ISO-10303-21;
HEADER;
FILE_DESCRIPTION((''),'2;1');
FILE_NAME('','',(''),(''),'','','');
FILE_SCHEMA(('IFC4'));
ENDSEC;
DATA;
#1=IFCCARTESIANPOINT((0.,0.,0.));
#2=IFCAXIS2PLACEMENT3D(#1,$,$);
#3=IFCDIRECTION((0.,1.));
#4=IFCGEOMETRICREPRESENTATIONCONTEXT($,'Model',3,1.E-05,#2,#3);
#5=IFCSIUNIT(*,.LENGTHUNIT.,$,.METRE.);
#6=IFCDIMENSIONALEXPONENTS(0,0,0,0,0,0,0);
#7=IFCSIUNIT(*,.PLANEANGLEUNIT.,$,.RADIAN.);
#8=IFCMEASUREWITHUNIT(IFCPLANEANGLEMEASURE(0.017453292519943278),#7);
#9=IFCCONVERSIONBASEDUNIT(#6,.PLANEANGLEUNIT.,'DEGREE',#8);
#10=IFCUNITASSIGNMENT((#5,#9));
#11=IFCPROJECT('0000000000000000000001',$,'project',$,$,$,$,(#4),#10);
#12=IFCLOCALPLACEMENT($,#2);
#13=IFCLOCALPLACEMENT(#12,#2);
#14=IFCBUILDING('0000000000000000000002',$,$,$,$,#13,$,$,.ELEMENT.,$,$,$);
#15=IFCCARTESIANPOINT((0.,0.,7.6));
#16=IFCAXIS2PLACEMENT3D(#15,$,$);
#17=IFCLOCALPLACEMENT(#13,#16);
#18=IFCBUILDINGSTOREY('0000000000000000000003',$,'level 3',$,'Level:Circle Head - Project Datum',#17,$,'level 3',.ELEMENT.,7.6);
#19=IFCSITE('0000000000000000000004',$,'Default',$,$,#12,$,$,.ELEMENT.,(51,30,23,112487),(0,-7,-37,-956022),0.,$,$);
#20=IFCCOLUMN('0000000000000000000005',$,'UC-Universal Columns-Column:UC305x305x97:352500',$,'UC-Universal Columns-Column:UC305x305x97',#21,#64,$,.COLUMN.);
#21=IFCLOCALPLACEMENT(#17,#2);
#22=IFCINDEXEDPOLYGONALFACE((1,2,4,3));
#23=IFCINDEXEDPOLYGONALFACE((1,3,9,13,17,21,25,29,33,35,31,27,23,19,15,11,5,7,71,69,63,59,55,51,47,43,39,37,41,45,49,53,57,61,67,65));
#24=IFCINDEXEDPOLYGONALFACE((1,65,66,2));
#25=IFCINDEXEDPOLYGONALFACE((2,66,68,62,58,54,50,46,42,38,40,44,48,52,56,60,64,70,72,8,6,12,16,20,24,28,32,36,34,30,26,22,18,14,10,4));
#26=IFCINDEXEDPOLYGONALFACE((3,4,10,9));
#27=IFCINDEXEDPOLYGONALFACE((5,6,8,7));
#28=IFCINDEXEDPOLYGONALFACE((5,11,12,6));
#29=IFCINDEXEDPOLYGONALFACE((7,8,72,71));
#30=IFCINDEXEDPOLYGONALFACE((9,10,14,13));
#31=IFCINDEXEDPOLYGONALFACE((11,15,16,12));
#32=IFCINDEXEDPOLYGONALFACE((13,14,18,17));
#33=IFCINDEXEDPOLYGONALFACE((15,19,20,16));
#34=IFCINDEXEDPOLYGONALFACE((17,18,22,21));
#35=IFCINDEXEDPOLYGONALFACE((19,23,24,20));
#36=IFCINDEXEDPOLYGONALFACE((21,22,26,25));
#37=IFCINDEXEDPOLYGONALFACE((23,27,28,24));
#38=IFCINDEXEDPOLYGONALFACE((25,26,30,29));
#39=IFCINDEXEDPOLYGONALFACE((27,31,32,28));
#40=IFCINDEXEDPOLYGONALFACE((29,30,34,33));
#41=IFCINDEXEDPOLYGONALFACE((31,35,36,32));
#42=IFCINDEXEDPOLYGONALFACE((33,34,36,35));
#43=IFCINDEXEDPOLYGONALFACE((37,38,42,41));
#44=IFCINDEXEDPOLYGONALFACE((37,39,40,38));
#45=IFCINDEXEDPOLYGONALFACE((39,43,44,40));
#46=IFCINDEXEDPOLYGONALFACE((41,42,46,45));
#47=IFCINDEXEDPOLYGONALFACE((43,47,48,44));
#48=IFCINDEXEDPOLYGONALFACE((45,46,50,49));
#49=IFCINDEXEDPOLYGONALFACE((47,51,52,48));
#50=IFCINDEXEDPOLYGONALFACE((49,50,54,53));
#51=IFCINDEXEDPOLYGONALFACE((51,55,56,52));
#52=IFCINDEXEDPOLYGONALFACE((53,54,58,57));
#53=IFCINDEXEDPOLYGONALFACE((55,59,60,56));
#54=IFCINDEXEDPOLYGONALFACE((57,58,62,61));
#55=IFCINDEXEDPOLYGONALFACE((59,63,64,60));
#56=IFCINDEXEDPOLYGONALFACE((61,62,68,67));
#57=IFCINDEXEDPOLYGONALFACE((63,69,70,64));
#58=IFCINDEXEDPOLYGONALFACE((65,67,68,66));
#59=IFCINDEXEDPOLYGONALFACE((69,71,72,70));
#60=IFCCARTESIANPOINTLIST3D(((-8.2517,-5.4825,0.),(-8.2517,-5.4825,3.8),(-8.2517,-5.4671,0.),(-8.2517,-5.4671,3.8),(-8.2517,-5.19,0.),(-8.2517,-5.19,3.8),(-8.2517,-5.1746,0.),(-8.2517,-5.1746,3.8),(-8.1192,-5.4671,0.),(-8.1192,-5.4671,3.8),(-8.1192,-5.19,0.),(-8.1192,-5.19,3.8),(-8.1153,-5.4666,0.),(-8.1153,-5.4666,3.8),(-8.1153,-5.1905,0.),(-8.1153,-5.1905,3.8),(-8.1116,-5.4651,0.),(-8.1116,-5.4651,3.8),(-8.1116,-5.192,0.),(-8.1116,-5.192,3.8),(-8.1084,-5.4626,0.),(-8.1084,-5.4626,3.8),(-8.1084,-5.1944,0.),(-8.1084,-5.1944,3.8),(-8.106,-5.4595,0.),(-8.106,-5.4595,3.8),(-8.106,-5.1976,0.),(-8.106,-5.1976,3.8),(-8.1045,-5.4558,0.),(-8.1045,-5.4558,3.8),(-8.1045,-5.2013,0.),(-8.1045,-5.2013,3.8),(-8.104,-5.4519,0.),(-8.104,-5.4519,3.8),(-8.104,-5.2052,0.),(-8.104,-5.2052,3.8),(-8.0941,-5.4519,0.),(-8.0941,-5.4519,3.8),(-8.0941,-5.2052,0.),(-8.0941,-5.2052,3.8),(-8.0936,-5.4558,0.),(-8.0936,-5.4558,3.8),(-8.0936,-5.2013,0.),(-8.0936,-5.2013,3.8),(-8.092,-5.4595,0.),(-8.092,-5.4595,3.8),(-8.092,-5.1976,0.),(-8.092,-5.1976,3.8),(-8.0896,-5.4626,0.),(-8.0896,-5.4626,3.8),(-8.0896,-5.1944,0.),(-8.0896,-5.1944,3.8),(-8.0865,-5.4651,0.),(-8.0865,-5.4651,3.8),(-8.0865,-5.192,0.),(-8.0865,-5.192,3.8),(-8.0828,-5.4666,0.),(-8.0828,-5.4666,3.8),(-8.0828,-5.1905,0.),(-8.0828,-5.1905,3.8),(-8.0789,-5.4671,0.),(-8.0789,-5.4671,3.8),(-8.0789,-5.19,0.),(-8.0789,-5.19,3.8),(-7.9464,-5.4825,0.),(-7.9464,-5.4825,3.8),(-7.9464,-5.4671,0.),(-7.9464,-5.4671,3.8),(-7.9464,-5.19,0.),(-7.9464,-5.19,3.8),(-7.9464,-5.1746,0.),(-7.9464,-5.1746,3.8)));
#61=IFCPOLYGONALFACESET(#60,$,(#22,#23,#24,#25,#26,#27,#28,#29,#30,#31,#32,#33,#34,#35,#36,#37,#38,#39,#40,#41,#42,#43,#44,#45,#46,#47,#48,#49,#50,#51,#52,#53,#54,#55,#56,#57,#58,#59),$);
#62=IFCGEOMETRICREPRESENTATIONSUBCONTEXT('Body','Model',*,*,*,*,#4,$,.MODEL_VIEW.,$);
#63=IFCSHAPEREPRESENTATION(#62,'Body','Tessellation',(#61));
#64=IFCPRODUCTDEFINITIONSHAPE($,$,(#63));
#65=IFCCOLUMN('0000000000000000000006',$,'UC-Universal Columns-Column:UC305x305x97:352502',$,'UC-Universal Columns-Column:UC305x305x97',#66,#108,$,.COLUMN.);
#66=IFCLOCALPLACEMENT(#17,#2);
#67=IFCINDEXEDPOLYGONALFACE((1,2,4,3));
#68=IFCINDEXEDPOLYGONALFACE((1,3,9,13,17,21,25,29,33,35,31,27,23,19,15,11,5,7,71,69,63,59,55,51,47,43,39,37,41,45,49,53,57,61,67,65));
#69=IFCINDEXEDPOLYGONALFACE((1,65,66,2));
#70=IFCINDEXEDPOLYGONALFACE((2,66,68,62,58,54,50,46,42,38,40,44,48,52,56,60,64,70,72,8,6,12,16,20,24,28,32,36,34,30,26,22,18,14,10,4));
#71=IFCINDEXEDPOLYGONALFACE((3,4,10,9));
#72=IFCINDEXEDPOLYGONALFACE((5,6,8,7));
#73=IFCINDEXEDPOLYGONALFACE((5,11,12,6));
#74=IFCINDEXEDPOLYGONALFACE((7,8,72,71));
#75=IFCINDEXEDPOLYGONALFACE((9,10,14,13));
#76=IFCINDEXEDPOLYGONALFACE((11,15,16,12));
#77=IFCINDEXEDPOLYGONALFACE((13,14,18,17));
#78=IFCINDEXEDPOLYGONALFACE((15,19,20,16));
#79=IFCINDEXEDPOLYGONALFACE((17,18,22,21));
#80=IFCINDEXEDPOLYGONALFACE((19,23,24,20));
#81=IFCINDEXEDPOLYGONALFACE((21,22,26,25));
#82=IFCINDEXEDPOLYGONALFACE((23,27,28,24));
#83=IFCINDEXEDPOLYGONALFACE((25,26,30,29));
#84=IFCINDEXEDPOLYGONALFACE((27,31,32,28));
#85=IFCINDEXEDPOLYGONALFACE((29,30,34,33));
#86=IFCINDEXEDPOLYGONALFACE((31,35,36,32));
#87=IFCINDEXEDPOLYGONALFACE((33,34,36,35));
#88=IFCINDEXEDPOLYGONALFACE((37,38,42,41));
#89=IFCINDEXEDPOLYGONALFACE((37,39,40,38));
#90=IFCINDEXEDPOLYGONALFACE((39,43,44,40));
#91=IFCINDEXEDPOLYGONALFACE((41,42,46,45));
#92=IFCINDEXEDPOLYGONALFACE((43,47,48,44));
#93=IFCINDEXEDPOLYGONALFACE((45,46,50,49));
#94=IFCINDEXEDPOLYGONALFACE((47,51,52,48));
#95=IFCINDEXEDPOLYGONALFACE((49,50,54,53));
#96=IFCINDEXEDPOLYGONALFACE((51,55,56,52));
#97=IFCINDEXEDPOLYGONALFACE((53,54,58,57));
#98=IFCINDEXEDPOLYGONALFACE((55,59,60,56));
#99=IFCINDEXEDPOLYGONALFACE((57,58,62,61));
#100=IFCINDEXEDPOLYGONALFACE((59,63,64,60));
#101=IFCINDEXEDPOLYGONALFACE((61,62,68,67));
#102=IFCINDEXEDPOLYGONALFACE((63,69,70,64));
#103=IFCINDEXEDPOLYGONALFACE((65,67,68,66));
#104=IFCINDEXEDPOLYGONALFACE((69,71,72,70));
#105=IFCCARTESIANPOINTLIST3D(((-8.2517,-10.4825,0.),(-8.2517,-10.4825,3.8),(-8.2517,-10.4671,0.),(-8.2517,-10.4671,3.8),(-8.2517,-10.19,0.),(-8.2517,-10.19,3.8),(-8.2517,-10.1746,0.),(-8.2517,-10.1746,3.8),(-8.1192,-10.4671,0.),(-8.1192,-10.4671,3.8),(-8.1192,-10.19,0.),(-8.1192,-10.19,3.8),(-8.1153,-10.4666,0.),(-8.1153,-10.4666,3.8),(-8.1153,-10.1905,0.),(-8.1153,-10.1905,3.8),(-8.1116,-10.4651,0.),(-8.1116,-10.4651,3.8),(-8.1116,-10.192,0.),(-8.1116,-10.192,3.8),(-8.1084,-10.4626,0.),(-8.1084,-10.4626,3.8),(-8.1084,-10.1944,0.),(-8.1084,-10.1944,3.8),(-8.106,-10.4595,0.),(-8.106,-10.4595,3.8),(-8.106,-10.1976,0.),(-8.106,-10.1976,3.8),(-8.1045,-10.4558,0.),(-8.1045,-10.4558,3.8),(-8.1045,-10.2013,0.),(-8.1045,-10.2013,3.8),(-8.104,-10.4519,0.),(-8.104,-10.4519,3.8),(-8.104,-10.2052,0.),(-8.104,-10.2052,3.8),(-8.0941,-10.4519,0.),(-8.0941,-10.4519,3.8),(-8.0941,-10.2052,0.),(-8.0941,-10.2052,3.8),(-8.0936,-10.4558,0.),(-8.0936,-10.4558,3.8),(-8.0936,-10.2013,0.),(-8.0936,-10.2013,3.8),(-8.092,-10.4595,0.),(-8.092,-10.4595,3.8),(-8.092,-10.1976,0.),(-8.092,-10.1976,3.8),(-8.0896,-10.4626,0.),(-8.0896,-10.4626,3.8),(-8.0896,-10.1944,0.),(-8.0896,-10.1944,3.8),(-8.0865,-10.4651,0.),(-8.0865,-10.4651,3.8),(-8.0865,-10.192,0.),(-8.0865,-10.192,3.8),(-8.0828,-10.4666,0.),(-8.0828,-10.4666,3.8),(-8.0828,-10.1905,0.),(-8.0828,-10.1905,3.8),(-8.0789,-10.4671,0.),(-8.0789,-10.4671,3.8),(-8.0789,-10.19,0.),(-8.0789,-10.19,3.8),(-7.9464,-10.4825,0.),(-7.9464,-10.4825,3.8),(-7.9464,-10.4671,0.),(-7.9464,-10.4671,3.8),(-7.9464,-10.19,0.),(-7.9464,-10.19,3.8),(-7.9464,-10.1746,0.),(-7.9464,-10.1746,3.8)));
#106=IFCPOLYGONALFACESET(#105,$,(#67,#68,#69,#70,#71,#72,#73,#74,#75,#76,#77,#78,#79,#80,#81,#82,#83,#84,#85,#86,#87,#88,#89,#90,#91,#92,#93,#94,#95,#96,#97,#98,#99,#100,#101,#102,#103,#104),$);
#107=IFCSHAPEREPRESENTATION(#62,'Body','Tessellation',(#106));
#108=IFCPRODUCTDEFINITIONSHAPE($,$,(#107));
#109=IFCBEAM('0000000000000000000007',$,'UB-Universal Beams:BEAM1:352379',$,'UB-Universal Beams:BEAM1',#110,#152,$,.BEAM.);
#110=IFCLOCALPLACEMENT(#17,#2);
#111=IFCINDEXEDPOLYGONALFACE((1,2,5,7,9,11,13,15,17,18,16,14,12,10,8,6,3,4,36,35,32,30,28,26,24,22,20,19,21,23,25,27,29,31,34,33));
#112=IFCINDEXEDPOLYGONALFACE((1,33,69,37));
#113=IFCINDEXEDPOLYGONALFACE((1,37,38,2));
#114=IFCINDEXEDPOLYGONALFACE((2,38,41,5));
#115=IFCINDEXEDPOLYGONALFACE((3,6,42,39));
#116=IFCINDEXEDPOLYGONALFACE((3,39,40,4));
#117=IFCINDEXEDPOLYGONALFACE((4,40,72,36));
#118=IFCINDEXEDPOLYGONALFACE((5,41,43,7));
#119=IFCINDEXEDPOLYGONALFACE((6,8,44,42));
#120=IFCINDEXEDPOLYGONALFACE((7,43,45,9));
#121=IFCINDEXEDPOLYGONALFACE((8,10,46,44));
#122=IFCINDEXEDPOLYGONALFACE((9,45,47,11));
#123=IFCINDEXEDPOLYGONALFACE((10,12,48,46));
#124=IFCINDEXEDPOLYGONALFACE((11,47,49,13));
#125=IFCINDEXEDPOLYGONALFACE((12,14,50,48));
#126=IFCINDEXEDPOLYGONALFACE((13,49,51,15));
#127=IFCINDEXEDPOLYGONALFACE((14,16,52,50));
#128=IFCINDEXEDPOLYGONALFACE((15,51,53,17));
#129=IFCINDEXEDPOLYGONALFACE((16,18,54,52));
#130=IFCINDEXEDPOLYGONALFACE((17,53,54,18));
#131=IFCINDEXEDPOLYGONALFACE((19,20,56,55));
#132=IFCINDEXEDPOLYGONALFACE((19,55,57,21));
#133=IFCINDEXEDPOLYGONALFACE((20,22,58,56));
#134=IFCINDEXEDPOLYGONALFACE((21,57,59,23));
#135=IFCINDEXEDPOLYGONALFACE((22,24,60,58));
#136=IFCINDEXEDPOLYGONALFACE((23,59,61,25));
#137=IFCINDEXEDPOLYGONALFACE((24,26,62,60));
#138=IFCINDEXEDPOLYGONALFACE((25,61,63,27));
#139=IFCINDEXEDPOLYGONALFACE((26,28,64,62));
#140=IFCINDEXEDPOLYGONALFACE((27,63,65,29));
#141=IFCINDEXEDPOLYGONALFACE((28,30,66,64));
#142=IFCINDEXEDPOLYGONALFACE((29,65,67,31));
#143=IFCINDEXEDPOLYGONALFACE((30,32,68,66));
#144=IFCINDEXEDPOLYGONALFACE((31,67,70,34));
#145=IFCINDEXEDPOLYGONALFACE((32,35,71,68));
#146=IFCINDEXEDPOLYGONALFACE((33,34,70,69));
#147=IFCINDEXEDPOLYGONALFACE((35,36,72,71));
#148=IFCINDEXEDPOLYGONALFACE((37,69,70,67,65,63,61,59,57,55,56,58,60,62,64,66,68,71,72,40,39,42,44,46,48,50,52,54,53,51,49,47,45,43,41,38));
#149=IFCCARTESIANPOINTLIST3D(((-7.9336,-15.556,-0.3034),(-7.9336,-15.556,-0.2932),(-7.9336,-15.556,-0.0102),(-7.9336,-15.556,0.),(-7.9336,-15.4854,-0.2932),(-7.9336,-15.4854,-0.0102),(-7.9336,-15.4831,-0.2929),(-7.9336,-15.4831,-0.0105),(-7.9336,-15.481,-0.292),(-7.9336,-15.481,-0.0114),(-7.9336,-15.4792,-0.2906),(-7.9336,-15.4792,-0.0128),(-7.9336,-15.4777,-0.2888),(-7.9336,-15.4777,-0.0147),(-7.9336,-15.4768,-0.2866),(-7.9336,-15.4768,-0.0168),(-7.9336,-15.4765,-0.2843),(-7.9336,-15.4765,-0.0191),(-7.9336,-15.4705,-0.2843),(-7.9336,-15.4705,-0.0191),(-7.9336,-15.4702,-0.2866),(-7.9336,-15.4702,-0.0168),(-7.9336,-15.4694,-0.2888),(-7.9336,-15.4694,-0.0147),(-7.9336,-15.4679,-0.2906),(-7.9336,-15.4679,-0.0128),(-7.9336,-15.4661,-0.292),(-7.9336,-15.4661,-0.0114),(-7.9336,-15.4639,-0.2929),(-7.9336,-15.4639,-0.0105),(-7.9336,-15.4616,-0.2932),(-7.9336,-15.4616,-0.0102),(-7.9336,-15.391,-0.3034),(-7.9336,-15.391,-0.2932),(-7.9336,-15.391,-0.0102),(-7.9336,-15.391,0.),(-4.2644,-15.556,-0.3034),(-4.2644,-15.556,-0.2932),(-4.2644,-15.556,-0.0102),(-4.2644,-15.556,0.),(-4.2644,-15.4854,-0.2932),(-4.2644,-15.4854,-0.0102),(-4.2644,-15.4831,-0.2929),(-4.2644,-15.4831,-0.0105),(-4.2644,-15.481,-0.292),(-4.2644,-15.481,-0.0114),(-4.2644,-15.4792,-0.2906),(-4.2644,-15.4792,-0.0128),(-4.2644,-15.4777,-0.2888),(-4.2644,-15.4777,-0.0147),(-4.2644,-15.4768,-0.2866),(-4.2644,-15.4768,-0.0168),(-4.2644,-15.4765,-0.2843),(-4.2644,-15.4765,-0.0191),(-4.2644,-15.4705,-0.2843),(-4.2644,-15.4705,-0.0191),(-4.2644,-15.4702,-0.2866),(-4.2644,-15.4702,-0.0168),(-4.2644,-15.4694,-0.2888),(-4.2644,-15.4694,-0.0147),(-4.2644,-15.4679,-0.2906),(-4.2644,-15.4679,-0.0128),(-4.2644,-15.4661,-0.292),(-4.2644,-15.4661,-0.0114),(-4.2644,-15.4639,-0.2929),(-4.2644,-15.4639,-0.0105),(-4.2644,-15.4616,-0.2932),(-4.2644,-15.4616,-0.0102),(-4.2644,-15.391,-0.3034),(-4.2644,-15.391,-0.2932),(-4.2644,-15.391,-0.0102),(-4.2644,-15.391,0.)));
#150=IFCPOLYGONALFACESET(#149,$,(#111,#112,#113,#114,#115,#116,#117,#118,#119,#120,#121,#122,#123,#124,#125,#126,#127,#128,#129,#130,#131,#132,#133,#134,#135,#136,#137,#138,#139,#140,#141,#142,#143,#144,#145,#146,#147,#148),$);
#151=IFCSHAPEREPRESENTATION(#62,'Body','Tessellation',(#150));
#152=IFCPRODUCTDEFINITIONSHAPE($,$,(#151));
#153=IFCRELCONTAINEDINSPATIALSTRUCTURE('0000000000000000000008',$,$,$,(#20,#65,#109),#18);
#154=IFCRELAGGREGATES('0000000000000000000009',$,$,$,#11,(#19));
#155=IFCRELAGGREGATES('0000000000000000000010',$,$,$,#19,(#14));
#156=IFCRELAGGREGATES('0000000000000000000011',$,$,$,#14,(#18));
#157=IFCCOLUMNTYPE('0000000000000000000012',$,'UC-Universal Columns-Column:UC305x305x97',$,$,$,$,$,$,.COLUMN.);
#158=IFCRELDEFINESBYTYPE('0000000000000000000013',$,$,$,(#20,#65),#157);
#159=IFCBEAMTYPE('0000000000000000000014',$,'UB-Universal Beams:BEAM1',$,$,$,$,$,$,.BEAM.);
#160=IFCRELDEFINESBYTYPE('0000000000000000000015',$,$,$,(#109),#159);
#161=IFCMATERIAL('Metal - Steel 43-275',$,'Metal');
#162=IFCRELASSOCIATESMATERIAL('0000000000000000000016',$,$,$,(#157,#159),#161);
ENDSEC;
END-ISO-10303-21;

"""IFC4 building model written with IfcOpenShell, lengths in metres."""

from ifc_helpers import new_model, entity, si_unit, converted_unit, direction, frame, frame_2d, origin, origin_2d_with_axis, place, context, subcontext, project, spatial, polyline, circle_curve, parameter, trimmed, segment, composite_curve, i_section, outline, extrude, source, transform, mapped, material, material_profile, profile_set, type_object, type_shapes, element, save


model = new_model("IFC4")

# Units and contexts
model_context = context("Model", 3, precision=1e-05, world=origin(), true_north=direction((0.0, 1.0)))
body_context = subcontext(model_context, "Body", "Model", "MODEL_VIEW")
ifc_project = project(units=[si_unit("LENGTHUNIT", "METRE"), converted_unit("PLANEANGLEUNIT", "DEGREE", entity("IfcPlaneAngleMeasure", 0.017453292519943278), si_unit("PLANEANGLEUNIT", "RADIAN"), dimensions=[0, 0, 0, 0, 0, 0, 0])], contexts=[model_context])

# Site, building, storey
site_placement = place(None, origin())
site = spatial("IfcSite", under=ifc_project, at=site_placement, Name="Default", CompositionType="ELEMENT", RefLatitude=(51, 30, 23, 112487), RefLongitude=(0, -7, -37, -956022), RefElevation=0.0)
building_placement = place(site_placement, origin())
building = spatial("IfcBuilding", under=site, at=building_placement, CompositionType="ELEMENT")
storey_placement = place(building_placement, frame((0.0, 0.0, 7.6)))
storey = spatial("IfcBuildingStorey", under=building, at=storey_placement, Name="level 3", ObjectType="Level:Circle Head - Project Datum", LongName="level 3", CompositionType="ELEMENT", Elevation=7.6)

# Columns
ifc_material_1 = material(Name="Metal - Steel 43-275", Category="Metal")
ifc_material_profile_1 = material_profile(ifc_material_1, i_section(OverallWidth=0.3053, OverallDepth=0.3079, WebThickness=0.0099, FlangeThickness=0.0154, FilletRadius=0.0152, at=frame_2d((0.0, 0.0), x_axis=(1.0, 0.0))), Name="UC305x305x97")
ifc_profile_set_1 = profile_set([ifc_material_profile_1], Name="UC305x305x97")
column_type = type_object("IfcColumnType", Name="UC-Universal Columns-Column:UC305x305x97", PredefinedType="COLUMN", material=ifc_profile_set_1)
shared_shape_1 = source(origin(), body_context, "Body", "SweptSolid", [
    extrude(i_section(OverallWidth=0.3053, OverallDepth=0.3079, WebThickness=0.0099, FlangeThickness=0.0154, FilletRadius=0.0152, at=origin_2d_with_axis()), frame((0.0, 0.0, 7.6), z_axis=(0.0, 0.0, 1.0), x_axis=(-1.0, 0.0, 0.0)), (0.0, 0.0, 1.0), 3.8),
])
type_shapes(column_type, [shared_shape_1])
for number, where, name in (
    (1, (-8.099, -5.3285, -7.6), "UC-Universal Columns-Column:UC305x305x97:352500"),
    (2, (-8.099, -10.3285, -7.6), "UC-Universal Columns-Column:UC305x305x97:352502"),
):
    element("IfcColumn", number, at=place(storey_placement, frame(where)), inside=storey, type_object=column_type, Name=name, ObjectType="UC-Universal Columns-Column:UC305x305x97", PredefinedType="COLUMN", context=body_context, shape_type="MappedRepresentation", body=[
        mapped(shared_shape_1, transform((0.0, 0.0, 0.0), scale=1.0)),
    ])

# Beam
ifc_material_profile_2 = material_profile(ifc_material_1, outline(composite_curve([segment(polyline([(-0.0825, -0.1415), (-0.0825, -0.1517)]), True, "CONTINUOUS"), segment(polyline([(-0.0825, -0.1517), (0.0825, -0.1517)]), True, "CONTINUOUS"), segment(polyline([(0.0825, -0.1517), (0.0825, -0.1415)]), True, "CONTINUOUS"), segment(polyline([(0.0825, -0.1415), (0.0119, -0.1415)]), True, "CONTINUOUS"), segment(trimmed(circle_curve(frame_2d((0.0119, -0.1326), x_axis=(1.0, 0.0)), 0.0089), [parameter(180.0)], [parameter(270.0)], True, "PARAMETER"), False, "CONTINUOUS"), segment(polyline([(0.003, -0.1326), (0.003, 0.1326)]), True, "CONTINUOUS"), segment(trimmed(circle_curve(frame_2d((0.0119, 0.1326), x_axis=(1.0, 0.0)), 0.0089), [parameter(90.0)], [parameter(180.0)], True, "PARAMETER"), False, "CONTINUOUS"), segment(polyline([(0.0119, 0.1415), (0.0825, 0.1415)]), True, "CONTINUOUS"), segment(polyline([(0.0825, 0.1415), (0.0825, 0.1517)]), True, "CONTINUOUS"), segment(polyline([(0.0825, 0.1517), (-0.0825, 0.1517)]), True, "CONTINUOUS"), segment(polyline([(-0.0825, 0.1517), (-0.0825, 0.1415)]), True, "CONTINUOUS"), segment(polyline([(-0.0825, 0.1415), (-0.0119, 0.1415)]), True, "CONTINUOUS"), segment(trimmed(circle_curve(frame_2d((-0.0119, 0.1326), x_axis=(1.0, 0.0)), 0.0089), [parameter(360.0)], [parameter(90.0)], True, "PARAMETER"), False, "CONTINUOUS"), segment(polyline([(-0.003, 0.1326), (-0.003, -0.1326)]), True, "CONTINUOUS"), segment(trimmed(circle_curve(frame_2d((-0.0119, -0.1326), x_axis=(1.0, 0.0)), 0.0089), [parameter(270.0)], [parameter(360.0)], True, "PARAMETER"), False, "CONTINUOUS"), segment(polyline([(-0.0119, -0.1415), (-0.0825, -0.1415)]), True, "CONTINUOUS")], self_intersect=False)), Name="BEAM1")
ifc_profile_set_2 = profile_set([ifc_material_profile_2], Name="BEAM1")
beam_type_1 = type_object("IfcBeamType", Name="UB-Universal Beams:BEAM1", PredefinedType="BEAM", material=ifc_profile_set_2)
shared_shape_2 = source(origin(), body_context, "Body", "SweptSolid", [
    extrude(outline(composite_curve([segment(polyline([(-0.0825, -0.1415), (-0.0825, -0.1517)]), True, "CONTINUOUS"), segment(polyline([(-0.0825, -0.1517), (0.0825, -0.1517)]), True, "CONTINUOUS"), segment(polyline([(0.0825, -0.1517), (0.0825, -0.1415)]), True, "CONTINUOUS"), segment(polyline([(0.0825, -0.1415), (0.0119, -0.1415)]), True, "CONTINUOUS"), segment(trimmed(circle_curve(frame_2d((0.0119, -0.1326), x_axis=(0.0, -1.0)), 0.0089), [parameter(270.0)], [parameter(360.0)], True, "PARAMETER"), False, "CONTINUOUS"), segment(polyline([(0.003, -0.1326), (0.003, 0.1326)]), True, "CONTINUOUS"), segment(trimmed(circle_curve(frame_2d((0.0119, 0.1326), x_axis=(-1.0, 0.0)), 0.0089), [parameter(270.0)], [parameter(360.0)], True, "PARAMETER"), False, "CONTINUOUS"), segment(polyline([(0.0119, 0.1415), (0.0825, 0.1415)]), True, "CONTINUOUS"), segment(polyline([(0.0825, 0.1415), (0.0825, 0.1517)]), True, "CONTINUOUS"), segment(polyline([(0.0825, 0.1517), (-0.0825, 0.1517)]), True, "CONTINUOUS"), segment(polyline([(-0.0825, 0.1517), (-0.0825, 0.1415)]), True, "CONTINUOUS"), segment(polyline([(-0.0825, 0.1415), (-0.0119, 0.1415)]), True, "CONTINUOUS"), segment(trimmed(circle_curve(frame_2d((-0.0119, 0.1326), x_axis=(0.0, 1.0)), 0.0089), [parameter(270.0)], [parameter(360.0)], True, "PARAMETER"), False, "CONTINUOUS"), segment(polyline([(-0.003, 0.1326), (-0.003, -0.1326)]), True, "CONTINUOUS"), segment(trimmed(circle_curve(frame_2d((-0.0119, -0.1326), x_axis=(1.0, 0.0)), 0.0089), [parameter(270.0)], [parameter(0.0)], True, "PARAMETER"), False, "CONTINUOUS"), segment(polyline([(-0.0119, -0.1415), (-0.0825, -0.1415)]), True, "CONTINUOUS")], self_intersect=False)), frame((-1.8346, 0.0, 0.0), z_axis=(-1.0, 0.0, 0.0), x_axis=(0.0, -1.0, 0.0)), (0.0, 0.0, -1.0), 3.6692),
])
type_shapes(beam_type_1, [shared_shape_2])
beam_placement = place(storey_placement, frame((-6.099, -15.4735, -0.1517), z_axis=(0.0, 0.0, 1.0), x_axis=(-1.0, 0.0, 0.0)))
element("IfcBeam", 3, at=beam_placement, inside=storey, type_object=beam_type_1, Name="UB-Universal Beams:BEAM1:352379", ObjectType="UB-Universal Beams:BEAM1", PredefinedType="BEAM", context=body_context, shape_type="MappedRepresentation", body=[
    mapped(shared_shape_2, transform((0.0, 0.0, 0.0), scale=1.0)),
])

save(model, "model.ifc")
